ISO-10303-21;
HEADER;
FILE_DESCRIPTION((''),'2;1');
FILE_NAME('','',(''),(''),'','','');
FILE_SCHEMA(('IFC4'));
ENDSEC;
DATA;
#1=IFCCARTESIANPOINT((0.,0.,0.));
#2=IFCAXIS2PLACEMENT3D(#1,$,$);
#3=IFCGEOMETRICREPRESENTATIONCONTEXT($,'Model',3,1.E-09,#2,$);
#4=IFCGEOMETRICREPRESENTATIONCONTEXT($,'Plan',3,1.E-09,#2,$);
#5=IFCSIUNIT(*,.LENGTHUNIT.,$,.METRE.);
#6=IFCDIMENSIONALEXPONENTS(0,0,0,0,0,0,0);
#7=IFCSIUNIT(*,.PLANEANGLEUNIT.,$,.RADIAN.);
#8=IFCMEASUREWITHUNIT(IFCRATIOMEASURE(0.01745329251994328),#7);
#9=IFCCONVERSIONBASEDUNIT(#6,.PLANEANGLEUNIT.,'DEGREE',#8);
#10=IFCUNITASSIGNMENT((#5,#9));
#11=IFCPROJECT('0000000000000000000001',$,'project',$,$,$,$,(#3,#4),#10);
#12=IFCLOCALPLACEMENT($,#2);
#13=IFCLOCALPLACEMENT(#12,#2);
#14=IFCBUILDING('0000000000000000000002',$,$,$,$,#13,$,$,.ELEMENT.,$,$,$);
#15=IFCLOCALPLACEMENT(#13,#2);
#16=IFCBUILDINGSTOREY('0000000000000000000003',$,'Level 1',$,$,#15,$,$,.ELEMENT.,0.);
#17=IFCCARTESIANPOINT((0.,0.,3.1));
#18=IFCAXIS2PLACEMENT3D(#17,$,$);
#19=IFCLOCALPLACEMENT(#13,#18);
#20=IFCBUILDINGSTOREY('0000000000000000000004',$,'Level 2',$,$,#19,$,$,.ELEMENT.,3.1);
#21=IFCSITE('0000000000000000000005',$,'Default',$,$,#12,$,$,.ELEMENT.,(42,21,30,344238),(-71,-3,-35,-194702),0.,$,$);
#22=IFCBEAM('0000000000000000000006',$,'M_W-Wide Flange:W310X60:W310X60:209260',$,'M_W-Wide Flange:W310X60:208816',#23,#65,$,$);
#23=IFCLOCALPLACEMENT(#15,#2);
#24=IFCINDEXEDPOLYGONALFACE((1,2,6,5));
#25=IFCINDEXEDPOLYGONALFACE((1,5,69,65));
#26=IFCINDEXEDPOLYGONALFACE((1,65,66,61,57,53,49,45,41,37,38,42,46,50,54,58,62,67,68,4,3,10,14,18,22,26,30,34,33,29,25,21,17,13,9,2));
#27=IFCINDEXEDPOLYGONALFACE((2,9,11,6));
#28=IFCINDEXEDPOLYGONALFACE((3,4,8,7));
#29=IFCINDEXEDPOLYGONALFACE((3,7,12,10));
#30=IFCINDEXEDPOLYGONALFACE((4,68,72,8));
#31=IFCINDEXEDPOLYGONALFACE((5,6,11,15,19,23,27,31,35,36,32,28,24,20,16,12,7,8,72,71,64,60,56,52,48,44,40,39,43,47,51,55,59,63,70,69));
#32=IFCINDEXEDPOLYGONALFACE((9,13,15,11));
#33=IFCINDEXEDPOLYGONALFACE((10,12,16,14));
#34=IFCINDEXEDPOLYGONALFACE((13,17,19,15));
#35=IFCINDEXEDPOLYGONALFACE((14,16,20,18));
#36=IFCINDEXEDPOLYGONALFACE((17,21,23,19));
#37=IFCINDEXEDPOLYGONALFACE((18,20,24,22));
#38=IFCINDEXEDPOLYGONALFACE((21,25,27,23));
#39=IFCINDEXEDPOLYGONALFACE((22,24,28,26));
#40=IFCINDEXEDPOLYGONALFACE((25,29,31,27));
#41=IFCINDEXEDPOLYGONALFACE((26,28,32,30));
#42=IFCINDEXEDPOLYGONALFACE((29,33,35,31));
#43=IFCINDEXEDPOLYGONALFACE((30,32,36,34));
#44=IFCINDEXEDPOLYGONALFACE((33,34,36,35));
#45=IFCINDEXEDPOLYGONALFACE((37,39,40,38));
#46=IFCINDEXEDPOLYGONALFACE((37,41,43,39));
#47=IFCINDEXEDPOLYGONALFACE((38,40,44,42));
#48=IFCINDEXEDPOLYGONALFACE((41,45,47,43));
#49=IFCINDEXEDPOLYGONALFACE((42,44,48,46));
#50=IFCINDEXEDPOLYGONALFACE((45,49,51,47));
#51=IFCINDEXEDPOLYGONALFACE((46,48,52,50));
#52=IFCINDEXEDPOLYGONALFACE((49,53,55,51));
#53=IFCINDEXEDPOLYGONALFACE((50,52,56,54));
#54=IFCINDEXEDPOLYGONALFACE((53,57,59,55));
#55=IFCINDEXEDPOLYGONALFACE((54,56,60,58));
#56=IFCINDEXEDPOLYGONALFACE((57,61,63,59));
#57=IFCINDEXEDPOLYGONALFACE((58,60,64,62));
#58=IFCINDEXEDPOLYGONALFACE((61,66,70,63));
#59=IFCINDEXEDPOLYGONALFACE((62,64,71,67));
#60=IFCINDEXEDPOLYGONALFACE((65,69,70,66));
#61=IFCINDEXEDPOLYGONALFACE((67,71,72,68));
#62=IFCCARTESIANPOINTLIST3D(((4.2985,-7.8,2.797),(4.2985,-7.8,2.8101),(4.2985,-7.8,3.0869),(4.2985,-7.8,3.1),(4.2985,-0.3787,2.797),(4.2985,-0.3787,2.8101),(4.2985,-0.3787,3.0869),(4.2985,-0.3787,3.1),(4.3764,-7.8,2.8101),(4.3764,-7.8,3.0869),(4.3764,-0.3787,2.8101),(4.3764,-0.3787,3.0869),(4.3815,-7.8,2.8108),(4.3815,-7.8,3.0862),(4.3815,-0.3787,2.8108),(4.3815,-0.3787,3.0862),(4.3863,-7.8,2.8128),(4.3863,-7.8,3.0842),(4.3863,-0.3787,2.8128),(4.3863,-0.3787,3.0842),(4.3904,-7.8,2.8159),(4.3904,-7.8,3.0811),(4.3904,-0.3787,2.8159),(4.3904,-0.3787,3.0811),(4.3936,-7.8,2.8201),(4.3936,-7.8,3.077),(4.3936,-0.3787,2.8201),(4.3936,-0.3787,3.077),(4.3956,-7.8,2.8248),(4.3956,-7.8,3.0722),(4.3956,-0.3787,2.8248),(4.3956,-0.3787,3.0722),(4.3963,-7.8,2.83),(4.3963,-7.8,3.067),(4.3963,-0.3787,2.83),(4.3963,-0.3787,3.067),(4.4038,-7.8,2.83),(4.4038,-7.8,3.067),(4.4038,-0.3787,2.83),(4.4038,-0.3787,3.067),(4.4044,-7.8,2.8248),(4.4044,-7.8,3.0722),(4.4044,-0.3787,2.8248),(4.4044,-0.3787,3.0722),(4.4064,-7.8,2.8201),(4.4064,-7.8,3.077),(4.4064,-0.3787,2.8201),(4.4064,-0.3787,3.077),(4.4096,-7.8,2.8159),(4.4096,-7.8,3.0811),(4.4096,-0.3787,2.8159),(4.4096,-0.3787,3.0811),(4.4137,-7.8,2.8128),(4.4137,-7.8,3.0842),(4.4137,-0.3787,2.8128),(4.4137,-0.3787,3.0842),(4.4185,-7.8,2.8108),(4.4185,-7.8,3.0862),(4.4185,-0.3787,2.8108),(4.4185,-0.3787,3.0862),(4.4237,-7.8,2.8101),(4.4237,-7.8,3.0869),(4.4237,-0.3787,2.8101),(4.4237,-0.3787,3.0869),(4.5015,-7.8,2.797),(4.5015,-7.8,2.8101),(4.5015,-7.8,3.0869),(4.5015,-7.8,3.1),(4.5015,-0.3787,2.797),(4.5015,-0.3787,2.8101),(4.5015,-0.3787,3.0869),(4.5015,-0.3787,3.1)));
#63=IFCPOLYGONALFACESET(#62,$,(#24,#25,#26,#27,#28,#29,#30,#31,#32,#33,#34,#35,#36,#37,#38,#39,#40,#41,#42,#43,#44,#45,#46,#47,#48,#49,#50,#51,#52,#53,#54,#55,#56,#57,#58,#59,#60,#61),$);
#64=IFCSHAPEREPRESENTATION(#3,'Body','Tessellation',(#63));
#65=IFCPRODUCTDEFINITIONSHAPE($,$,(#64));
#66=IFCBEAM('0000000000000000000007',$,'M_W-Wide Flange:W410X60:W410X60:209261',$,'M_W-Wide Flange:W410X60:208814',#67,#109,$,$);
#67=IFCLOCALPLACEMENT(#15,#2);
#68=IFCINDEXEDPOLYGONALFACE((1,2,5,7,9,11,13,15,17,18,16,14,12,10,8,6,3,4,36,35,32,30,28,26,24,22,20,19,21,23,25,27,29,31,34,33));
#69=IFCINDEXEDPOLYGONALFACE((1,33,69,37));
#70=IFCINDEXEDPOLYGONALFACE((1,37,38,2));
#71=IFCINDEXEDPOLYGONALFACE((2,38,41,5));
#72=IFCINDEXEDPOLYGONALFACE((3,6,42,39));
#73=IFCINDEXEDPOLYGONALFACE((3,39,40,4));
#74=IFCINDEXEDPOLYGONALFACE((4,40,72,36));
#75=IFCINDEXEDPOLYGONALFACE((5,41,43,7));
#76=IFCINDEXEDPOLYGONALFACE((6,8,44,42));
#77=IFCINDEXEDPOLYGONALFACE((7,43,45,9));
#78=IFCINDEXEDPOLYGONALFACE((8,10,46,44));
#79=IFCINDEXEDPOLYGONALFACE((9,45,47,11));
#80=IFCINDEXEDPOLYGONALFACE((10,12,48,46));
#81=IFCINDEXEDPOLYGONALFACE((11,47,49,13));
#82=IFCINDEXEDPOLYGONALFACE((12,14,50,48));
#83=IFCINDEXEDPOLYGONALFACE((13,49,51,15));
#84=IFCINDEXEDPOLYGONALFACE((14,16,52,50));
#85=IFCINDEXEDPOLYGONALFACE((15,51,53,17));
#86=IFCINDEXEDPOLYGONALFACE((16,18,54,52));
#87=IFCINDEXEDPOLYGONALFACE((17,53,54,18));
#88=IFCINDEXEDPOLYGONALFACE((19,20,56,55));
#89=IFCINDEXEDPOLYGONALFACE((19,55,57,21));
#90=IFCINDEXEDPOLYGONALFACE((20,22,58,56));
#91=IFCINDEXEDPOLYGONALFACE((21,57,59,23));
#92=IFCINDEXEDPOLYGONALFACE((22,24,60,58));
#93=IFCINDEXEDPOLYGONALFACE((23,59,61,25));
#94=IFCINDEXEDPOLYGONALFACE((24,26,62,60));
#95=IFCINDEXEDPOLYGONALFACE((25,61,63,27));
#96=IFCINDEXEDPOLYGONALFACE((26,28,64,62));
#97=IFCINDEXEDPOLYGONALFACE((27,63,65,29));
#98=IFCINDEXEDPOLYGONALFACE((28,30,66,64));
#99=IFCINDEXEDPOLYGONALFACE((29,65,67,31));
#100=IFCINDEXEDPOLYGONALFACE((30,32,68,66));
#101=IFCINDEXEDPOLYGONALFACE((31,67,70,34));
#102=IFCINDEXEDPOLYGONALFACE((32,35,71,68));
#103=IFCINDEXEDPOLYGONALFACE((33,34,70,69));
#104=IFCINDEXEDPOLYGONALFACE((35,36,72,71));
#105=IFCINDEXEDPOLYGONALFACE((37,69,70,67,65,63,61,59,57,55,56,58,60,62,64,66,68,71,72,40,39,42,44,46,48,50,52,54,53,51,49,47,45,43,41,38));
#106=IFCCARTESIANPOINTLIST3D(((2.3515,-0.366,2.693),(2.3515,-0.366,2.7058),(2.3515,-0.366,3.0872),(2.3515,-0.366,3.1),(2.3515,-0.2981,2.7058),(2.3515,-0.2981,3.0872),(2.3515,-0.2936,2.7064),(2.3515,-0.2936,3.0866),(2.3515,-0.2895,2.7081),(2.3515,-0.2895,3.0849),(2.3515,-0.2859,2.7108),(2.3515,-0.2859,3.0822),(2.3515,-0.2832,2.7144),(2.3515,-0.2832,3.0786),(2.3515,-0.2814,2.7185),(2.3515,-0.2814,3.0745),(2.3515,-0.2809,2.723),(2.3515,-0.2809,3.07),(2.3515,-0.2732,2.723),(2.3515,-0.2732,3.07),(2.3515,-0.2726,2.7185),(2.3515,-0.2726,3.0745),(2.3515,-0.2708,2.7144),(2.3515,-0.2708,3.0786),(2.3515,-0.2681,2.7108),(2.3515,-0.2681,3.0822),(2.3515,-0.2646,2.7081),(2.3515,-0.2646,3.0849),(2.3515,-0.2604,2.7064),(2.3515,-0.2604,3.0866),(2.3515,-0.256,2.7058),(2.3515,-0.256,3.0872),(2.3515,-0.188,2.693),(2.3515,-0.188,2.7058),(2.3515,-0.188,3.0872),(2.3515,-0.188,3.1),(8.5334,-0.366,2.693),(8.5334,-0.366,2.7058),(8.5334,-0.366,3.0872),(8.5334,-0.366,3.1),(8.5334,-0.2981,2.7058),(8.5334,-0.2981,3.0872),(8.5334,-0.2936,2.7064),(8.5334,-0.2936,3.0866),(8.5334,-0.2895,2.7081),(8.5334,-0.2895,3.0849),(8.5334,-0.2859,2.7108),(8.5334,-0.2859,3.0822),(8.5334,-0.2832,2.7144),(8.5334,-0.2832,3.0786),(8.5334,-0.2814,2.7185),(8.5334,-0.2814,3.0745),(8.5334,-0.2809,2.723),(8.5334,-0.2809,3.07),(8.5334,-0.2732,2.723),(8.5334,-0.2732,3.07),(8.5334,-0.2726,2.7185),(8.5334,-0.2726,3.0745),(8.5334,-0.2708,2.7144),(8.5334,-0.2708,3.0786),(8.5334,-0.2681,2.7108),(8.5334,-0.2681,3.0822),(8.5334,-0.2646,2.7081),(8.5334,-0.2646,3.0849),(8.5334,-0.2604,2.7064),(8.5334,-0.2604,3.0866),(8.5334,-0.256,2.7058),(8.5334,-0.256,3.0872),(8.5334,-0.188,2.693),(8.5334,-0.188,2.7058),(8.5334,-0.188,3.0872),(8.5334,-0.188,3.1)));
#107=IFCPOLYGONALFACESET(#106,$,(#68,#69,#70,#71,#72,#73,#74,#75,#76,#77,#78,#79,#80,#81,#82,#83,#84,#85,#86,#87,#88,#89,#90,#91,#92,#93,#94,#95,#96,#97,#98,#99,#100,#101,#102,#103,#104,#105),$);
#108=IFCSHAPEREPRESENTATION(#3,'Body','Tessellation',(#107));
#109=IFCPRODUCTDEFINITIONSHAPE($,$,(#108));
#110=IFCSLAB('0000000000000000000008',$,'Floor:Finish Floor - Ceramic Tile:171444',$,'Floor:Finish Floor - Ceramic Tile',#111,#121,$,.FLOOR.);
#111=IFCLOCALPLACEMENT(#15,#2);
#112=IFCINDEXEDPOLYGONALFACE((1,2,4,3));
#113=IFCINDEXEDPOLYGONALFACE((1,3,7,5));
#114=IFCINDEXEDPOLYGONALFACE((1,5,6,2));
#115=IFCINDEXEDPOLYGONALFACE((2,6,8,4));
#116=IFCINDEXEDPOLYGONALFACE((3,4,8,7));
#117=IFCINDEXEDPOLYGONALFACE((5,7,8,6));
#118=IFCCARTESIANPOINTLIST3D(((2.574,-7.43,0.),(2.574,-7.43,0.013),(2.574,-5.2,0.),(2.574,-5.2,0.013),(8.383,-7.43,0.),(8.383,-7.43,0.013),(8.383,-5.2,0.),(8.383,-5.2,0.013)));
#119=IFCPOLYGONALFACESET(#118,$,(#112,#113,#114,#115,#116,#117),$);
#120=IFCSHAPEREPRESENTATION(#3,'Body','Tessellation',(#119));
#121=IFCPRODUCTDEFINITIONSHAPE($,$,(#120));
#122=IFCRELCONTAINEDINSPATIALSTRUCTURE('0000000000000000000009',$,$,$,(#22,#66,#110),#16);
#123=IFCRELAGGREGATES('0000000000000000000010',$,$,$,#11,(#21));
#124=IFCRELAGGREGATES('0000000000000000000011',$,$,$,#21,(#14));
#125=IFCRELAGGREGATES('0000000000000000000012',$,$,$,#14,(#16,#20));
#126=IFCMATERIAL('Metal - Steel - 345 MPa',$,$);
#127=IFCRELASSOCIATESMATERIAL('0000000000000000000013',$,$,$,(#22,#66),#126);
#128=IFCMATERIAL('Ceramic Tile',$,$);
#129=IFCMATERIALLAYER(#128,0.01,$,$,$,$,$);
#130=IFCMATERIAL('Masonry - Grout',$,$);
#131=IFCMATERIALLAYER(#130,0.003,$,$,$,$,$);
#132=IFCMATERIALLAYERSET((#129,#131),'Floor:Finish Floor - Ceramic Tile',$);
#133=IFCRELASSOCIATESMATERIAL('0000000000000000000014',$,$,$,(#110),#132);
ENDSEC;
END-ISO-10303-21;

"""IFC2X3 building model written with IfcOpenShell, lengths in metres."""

from ifc_helpers import new_model, entity, si_unit, converted_unit, frame, frame_2d, origin, place, context, project, spatial, polyline, circle_curve, parameter, trimmed, segment, composite_curve, rectangle, outline, extrude, material, layer, layer_set, layer_usage, element, save


model = new_model("IFC2X3")

# Units and contexts
model_context = context("Model", 3, precision=1e-09, world=origin())
plan_context = context("Plan", 3, precision=1e-09, world=origin())
ifc_project = project(units=[si_unit("LENGTHUNIT", "METRE"), converted_unit("PLANEANGLEUNIT", "DEGREE", entity("IfcRatioMeasure", 0.01745329251994328), si_unit("PLANEANGLEUNIT", "RADIAN"), dimensions=[0, 0, 0, 0, 0, 0, 0])], contexts=[model_context, plan_context])

# Site, building, storey
site_placement = place(None, origin())
site = spatial("IfcSite", under=ifc_project, at=site_placement, Name="Default", CompositionType="ELEMENT", RefLatitude=(42, 21, 30, 344238), RefLongitude=(-71, -3, -35, -194702), RefElevation=0.0)
building_placement = place(site_placement, origin())
building = spatial("IfcBuilding", under=site, at=building_placement, CompositionType="ELEMENT")
storey_1_placement = place(building_placement, origin())
storey_1 = spatial("IfcBuildingStorey", under=building, at=storey_1_placement, Name="Level 1", CompositionType="ELEMENT", Elevation=0.0)

# Beams
ifc_material_1 = material(Name="Metal - Steel - 345 MPa")
beam_1_placement = place(storey_1_placement, frame((4.4, -7.8, 3.1)))
element("IfcBeam", 1, at=beam_1_placement, inside=storey_1, material=ifc_material_1, Name="M_W-Wide Flange:W310X60:W310X60:209260", ObjectType="M_W-Wide Flange:W310X60:208816", context=model_context, shape_type="SweptSolid", body=[
    extrude(outline(composite_curve([segment(polyline([(-0.1015, -0.1384), (-0.1015, -0.1515)]), True, "CONTINUOUS"), segment(polyline([(-0.1015, -0.1515), (0.1015, -0.1515)]), True, "CONTINUOUS"), segment(polyline([(0.1015, -0.1515), (0.1015, -0.1384)]), True, "CONTINUOUS"), segment(polyline([(0.1015, -0.1384), (0.0236, -0.1384)]), True, "CONTINUOUS"), segment(trimmed(circle_curve(frame_2d((0.0236, -0.1185), x_axis=(1.0, 0.0)), 0.0199), [parameter(180.0)], [parameter(270.0)], True, "PARAMETER"), False, "CONTINUOUS"), segment(polyline([(0.0037, -0.1185), (0.0037, 0.1185)]), True, "CONTINUOUS"), segment(trimmed(circle_curve(frame_2d((0.0236, 0.1185), x_axis=(1.0, 0.0)), 0.0199), [parameter(90.0)], [parameter(180.0)], True, "PARAMETER"), False, "CONTINUOUS"), segment(polyline([(0.0236, 0.1384), (0.1015, 0.1384)]), True, "CONTINUOUS"), segment(polyline([(0.1015, 0.1384), (0.1015, 0.1515)]), True, "CONTINUOUS"), segment(polyline([(0.1015, 0.1515), (-0.1015, 0.1515)]), True, "CONTINUOUS"), segment(polyline([(-0.1015, 0.1515), (-0.1015, 0.1384)]), True, "CONTINUOUS"), segment(polyline([(-0.1015, 0.1384), (-0.0237, 0.1384)]), True, "CONTINUOUS"), segment(trimmed(circle_curve(frame_2d((-0.0237, 0.1185), x_axis=(1.0, 0.0)), 0.0199), [parameter(360.0)], [parameter(90.0)], True, "PARAMETER"), False, "CONTINUOUS"), segment(polyline([(-0.0038, 0.1185), (-0.0038, -0.1185)]), True, "CONTINUOUS"), segment(trimmed(circle_curve(frame_2d((-0.0237, -0.1185), x_axis=(1.0, 0.0)), 0.0199), [parameter(270.0)], [parameter(0.0)], True, "PARAMETER"), False, "CONTINUOUS"), segment(polyline([(-0.0237, -0.1384), (-0.1015, -0.1384)]), True, "CONTINUOUS")], self_intersect=False)), frame((0.0, 0.0, -0.1515), z_axis=(0.0, -1.0, 0.0), x_axis=(1.0, 0.0, 0.0)), (0.0, 0.0, -1.0), 7.4213),
])
beam_2_placement = place(storey_1_placement, frame((8.5915, -0.277, 3.1), z_axis=(0.0, 0.0, 1.0), x_axis=(0.0, 1.0, 0.0)))
element("IfcBeam", 2, at=beam_2_placement, inside=storey_1, material=ifc_material_1, Name="M_W-Wide Flange:W410X60:W410X60:209261", ObjectType="M_W-Wide Flange:W410X60:208814", context=model_context, shape_type="SweptSolid", body=[
    extrude(outline(composite_curve([segment(polyline([(0.1907, -0.089), (0.2035, -0.089)]), True, "CONTINUOUS"), segment(polyline([(0.2035, -0.089), (0.2035, 0.089)]), True, "CONTINUOUS"), segment(polyline([(0.2035, 0.089), (0.1907, 0.089)]), True, "CONTINUOUS"), segment(polyline([(0.1907, 0.089), (0.1907, 0.021)]), True, "CONTINUOUS"), segment(trimmed(circle_curve(frame_2d((0.1735, 0.021), x_axis=(1.0, 0.0)), 0.0172), [parameter(270.0)], [parameter(360.0)], True, "PARAMETER"), False, "CONTINUOUS"), segment(polyline([(0.1735, 0.0038), (-0.1735, 0.0038)]), True, "CONTINUOUS"), segment(trimmed(circle_curve(frame_2d((-0.1735, 0.021), x_axis=(0.0, -1.0)), 0.0172), [parameter(270.0)], [parameter(360.0)], True, "PARAMETER"), False, "CONTINUOUS"), segment(polyline([(-0.1907, 0.021), (-0.1907, 0.089)]), True, "CONTINUOUS"), segment(polyline([(-0.1907, 0.089), (-0.2035, 0.089)]), True, "CONTINUOUS"), segment(polyline([(-0.2035, 0.089), (-0.2035, -0.089)]), True, "CONTINUOUS"), segment(polyline([(-0.2035, -0.089), (-0.1907, -0.089)]), True, "CONTINUOUS"), segment(polyline([(-0.1907, -0.089), (-0.1907, -0.0211)]), True, "CONTINUOUS"), segment(trimmed(circle_curve(frame_2d((-0.1735, -0.0211), x_axis=(-1.0, 0.0)), 0.0172), [parameter(270.0)], [parameter(0.0)], True, "PARAMETER"), False, "CONTINUOUS"), segment(polyline([(-0.1735, -0.0039), (0.1735, -0.0039)]), True, "CONTINUOUS"), segment(trimmed(circle_curve(frame_2d((0.1735, -0.0211), x_axis=(0.0, 1.0)), 0.0172), [parameter(270.0)], [parameter(0.0)], True, "PARAMETER"), False, "CONTINUOUS"), segment(polyline([(0.1907, -0.0211), (0.1907, -0.089)]), True, "CONTINUOUS")], self_intersect=False)), frame((0.0, 6.24, -0.2035), z_axis=(0.0, -1.0, 0.0), x_axis=(0.0, 0.0, -1.0)), (0.0, 0.0, 1.0), 6.1819),
])

# Slab
ifc_material_2 = material(Name="Ceramic Tile")
ifc_layer_1 = layer(ifc_material_2, 0.01)
ifc_material_3 = material(Name="Masonry - Grout")
ifc_layer_2 = layer(ifc_material_3, 0.003)
ifc_layer_set_1 = layer_set([ifc_layer_1, ifc_layer_2], Name="Floor:Finish Floor - Ceramic Tile")
ifc_layer_usage_1 = layer_usage(ifc_layer_set_1, "AXIS3", "POSITIVE", 0.0)
slab_1_placement = place(storey_1_placement, frame((2.574, -7.43, 0.0)))
element("IfcSlab", 3, at=slab_1_placement, inside=storey_1, material=ifc_layer_usage_1, Name="Floor:Finish Floor - Ceramic Tile:171444", ObjectType="Floor:Finish Floor - Ceramic Tile", PredefinedType="FLOOR", context=model_context, shape_type="SweptSolid", body=[
    extrude(rectangle(XDim=5.809, YDim=2.23, at=frame_2d((0.0, 0.0), x_axis=(-1.0, 0.0))), frame((2.9045, 1.115, 0.013), z_axis=(0.0, 0.0, -1.0), x_axis=(-1.0, 0.0, 0.0)), (0.0, 0.0, 1.0), 0.013),
])

# Shared definitions
storey_2_placement = place(building_placement, frame((0.0, 0.0, 3.1)))
storey_2 = spatial("IfcBuildingStorey", under=building, at=storey_2_placement, Name="Level 2", CompositionType="ELEMENT", Elevation=3.1)

save(model, "model.ifc")
